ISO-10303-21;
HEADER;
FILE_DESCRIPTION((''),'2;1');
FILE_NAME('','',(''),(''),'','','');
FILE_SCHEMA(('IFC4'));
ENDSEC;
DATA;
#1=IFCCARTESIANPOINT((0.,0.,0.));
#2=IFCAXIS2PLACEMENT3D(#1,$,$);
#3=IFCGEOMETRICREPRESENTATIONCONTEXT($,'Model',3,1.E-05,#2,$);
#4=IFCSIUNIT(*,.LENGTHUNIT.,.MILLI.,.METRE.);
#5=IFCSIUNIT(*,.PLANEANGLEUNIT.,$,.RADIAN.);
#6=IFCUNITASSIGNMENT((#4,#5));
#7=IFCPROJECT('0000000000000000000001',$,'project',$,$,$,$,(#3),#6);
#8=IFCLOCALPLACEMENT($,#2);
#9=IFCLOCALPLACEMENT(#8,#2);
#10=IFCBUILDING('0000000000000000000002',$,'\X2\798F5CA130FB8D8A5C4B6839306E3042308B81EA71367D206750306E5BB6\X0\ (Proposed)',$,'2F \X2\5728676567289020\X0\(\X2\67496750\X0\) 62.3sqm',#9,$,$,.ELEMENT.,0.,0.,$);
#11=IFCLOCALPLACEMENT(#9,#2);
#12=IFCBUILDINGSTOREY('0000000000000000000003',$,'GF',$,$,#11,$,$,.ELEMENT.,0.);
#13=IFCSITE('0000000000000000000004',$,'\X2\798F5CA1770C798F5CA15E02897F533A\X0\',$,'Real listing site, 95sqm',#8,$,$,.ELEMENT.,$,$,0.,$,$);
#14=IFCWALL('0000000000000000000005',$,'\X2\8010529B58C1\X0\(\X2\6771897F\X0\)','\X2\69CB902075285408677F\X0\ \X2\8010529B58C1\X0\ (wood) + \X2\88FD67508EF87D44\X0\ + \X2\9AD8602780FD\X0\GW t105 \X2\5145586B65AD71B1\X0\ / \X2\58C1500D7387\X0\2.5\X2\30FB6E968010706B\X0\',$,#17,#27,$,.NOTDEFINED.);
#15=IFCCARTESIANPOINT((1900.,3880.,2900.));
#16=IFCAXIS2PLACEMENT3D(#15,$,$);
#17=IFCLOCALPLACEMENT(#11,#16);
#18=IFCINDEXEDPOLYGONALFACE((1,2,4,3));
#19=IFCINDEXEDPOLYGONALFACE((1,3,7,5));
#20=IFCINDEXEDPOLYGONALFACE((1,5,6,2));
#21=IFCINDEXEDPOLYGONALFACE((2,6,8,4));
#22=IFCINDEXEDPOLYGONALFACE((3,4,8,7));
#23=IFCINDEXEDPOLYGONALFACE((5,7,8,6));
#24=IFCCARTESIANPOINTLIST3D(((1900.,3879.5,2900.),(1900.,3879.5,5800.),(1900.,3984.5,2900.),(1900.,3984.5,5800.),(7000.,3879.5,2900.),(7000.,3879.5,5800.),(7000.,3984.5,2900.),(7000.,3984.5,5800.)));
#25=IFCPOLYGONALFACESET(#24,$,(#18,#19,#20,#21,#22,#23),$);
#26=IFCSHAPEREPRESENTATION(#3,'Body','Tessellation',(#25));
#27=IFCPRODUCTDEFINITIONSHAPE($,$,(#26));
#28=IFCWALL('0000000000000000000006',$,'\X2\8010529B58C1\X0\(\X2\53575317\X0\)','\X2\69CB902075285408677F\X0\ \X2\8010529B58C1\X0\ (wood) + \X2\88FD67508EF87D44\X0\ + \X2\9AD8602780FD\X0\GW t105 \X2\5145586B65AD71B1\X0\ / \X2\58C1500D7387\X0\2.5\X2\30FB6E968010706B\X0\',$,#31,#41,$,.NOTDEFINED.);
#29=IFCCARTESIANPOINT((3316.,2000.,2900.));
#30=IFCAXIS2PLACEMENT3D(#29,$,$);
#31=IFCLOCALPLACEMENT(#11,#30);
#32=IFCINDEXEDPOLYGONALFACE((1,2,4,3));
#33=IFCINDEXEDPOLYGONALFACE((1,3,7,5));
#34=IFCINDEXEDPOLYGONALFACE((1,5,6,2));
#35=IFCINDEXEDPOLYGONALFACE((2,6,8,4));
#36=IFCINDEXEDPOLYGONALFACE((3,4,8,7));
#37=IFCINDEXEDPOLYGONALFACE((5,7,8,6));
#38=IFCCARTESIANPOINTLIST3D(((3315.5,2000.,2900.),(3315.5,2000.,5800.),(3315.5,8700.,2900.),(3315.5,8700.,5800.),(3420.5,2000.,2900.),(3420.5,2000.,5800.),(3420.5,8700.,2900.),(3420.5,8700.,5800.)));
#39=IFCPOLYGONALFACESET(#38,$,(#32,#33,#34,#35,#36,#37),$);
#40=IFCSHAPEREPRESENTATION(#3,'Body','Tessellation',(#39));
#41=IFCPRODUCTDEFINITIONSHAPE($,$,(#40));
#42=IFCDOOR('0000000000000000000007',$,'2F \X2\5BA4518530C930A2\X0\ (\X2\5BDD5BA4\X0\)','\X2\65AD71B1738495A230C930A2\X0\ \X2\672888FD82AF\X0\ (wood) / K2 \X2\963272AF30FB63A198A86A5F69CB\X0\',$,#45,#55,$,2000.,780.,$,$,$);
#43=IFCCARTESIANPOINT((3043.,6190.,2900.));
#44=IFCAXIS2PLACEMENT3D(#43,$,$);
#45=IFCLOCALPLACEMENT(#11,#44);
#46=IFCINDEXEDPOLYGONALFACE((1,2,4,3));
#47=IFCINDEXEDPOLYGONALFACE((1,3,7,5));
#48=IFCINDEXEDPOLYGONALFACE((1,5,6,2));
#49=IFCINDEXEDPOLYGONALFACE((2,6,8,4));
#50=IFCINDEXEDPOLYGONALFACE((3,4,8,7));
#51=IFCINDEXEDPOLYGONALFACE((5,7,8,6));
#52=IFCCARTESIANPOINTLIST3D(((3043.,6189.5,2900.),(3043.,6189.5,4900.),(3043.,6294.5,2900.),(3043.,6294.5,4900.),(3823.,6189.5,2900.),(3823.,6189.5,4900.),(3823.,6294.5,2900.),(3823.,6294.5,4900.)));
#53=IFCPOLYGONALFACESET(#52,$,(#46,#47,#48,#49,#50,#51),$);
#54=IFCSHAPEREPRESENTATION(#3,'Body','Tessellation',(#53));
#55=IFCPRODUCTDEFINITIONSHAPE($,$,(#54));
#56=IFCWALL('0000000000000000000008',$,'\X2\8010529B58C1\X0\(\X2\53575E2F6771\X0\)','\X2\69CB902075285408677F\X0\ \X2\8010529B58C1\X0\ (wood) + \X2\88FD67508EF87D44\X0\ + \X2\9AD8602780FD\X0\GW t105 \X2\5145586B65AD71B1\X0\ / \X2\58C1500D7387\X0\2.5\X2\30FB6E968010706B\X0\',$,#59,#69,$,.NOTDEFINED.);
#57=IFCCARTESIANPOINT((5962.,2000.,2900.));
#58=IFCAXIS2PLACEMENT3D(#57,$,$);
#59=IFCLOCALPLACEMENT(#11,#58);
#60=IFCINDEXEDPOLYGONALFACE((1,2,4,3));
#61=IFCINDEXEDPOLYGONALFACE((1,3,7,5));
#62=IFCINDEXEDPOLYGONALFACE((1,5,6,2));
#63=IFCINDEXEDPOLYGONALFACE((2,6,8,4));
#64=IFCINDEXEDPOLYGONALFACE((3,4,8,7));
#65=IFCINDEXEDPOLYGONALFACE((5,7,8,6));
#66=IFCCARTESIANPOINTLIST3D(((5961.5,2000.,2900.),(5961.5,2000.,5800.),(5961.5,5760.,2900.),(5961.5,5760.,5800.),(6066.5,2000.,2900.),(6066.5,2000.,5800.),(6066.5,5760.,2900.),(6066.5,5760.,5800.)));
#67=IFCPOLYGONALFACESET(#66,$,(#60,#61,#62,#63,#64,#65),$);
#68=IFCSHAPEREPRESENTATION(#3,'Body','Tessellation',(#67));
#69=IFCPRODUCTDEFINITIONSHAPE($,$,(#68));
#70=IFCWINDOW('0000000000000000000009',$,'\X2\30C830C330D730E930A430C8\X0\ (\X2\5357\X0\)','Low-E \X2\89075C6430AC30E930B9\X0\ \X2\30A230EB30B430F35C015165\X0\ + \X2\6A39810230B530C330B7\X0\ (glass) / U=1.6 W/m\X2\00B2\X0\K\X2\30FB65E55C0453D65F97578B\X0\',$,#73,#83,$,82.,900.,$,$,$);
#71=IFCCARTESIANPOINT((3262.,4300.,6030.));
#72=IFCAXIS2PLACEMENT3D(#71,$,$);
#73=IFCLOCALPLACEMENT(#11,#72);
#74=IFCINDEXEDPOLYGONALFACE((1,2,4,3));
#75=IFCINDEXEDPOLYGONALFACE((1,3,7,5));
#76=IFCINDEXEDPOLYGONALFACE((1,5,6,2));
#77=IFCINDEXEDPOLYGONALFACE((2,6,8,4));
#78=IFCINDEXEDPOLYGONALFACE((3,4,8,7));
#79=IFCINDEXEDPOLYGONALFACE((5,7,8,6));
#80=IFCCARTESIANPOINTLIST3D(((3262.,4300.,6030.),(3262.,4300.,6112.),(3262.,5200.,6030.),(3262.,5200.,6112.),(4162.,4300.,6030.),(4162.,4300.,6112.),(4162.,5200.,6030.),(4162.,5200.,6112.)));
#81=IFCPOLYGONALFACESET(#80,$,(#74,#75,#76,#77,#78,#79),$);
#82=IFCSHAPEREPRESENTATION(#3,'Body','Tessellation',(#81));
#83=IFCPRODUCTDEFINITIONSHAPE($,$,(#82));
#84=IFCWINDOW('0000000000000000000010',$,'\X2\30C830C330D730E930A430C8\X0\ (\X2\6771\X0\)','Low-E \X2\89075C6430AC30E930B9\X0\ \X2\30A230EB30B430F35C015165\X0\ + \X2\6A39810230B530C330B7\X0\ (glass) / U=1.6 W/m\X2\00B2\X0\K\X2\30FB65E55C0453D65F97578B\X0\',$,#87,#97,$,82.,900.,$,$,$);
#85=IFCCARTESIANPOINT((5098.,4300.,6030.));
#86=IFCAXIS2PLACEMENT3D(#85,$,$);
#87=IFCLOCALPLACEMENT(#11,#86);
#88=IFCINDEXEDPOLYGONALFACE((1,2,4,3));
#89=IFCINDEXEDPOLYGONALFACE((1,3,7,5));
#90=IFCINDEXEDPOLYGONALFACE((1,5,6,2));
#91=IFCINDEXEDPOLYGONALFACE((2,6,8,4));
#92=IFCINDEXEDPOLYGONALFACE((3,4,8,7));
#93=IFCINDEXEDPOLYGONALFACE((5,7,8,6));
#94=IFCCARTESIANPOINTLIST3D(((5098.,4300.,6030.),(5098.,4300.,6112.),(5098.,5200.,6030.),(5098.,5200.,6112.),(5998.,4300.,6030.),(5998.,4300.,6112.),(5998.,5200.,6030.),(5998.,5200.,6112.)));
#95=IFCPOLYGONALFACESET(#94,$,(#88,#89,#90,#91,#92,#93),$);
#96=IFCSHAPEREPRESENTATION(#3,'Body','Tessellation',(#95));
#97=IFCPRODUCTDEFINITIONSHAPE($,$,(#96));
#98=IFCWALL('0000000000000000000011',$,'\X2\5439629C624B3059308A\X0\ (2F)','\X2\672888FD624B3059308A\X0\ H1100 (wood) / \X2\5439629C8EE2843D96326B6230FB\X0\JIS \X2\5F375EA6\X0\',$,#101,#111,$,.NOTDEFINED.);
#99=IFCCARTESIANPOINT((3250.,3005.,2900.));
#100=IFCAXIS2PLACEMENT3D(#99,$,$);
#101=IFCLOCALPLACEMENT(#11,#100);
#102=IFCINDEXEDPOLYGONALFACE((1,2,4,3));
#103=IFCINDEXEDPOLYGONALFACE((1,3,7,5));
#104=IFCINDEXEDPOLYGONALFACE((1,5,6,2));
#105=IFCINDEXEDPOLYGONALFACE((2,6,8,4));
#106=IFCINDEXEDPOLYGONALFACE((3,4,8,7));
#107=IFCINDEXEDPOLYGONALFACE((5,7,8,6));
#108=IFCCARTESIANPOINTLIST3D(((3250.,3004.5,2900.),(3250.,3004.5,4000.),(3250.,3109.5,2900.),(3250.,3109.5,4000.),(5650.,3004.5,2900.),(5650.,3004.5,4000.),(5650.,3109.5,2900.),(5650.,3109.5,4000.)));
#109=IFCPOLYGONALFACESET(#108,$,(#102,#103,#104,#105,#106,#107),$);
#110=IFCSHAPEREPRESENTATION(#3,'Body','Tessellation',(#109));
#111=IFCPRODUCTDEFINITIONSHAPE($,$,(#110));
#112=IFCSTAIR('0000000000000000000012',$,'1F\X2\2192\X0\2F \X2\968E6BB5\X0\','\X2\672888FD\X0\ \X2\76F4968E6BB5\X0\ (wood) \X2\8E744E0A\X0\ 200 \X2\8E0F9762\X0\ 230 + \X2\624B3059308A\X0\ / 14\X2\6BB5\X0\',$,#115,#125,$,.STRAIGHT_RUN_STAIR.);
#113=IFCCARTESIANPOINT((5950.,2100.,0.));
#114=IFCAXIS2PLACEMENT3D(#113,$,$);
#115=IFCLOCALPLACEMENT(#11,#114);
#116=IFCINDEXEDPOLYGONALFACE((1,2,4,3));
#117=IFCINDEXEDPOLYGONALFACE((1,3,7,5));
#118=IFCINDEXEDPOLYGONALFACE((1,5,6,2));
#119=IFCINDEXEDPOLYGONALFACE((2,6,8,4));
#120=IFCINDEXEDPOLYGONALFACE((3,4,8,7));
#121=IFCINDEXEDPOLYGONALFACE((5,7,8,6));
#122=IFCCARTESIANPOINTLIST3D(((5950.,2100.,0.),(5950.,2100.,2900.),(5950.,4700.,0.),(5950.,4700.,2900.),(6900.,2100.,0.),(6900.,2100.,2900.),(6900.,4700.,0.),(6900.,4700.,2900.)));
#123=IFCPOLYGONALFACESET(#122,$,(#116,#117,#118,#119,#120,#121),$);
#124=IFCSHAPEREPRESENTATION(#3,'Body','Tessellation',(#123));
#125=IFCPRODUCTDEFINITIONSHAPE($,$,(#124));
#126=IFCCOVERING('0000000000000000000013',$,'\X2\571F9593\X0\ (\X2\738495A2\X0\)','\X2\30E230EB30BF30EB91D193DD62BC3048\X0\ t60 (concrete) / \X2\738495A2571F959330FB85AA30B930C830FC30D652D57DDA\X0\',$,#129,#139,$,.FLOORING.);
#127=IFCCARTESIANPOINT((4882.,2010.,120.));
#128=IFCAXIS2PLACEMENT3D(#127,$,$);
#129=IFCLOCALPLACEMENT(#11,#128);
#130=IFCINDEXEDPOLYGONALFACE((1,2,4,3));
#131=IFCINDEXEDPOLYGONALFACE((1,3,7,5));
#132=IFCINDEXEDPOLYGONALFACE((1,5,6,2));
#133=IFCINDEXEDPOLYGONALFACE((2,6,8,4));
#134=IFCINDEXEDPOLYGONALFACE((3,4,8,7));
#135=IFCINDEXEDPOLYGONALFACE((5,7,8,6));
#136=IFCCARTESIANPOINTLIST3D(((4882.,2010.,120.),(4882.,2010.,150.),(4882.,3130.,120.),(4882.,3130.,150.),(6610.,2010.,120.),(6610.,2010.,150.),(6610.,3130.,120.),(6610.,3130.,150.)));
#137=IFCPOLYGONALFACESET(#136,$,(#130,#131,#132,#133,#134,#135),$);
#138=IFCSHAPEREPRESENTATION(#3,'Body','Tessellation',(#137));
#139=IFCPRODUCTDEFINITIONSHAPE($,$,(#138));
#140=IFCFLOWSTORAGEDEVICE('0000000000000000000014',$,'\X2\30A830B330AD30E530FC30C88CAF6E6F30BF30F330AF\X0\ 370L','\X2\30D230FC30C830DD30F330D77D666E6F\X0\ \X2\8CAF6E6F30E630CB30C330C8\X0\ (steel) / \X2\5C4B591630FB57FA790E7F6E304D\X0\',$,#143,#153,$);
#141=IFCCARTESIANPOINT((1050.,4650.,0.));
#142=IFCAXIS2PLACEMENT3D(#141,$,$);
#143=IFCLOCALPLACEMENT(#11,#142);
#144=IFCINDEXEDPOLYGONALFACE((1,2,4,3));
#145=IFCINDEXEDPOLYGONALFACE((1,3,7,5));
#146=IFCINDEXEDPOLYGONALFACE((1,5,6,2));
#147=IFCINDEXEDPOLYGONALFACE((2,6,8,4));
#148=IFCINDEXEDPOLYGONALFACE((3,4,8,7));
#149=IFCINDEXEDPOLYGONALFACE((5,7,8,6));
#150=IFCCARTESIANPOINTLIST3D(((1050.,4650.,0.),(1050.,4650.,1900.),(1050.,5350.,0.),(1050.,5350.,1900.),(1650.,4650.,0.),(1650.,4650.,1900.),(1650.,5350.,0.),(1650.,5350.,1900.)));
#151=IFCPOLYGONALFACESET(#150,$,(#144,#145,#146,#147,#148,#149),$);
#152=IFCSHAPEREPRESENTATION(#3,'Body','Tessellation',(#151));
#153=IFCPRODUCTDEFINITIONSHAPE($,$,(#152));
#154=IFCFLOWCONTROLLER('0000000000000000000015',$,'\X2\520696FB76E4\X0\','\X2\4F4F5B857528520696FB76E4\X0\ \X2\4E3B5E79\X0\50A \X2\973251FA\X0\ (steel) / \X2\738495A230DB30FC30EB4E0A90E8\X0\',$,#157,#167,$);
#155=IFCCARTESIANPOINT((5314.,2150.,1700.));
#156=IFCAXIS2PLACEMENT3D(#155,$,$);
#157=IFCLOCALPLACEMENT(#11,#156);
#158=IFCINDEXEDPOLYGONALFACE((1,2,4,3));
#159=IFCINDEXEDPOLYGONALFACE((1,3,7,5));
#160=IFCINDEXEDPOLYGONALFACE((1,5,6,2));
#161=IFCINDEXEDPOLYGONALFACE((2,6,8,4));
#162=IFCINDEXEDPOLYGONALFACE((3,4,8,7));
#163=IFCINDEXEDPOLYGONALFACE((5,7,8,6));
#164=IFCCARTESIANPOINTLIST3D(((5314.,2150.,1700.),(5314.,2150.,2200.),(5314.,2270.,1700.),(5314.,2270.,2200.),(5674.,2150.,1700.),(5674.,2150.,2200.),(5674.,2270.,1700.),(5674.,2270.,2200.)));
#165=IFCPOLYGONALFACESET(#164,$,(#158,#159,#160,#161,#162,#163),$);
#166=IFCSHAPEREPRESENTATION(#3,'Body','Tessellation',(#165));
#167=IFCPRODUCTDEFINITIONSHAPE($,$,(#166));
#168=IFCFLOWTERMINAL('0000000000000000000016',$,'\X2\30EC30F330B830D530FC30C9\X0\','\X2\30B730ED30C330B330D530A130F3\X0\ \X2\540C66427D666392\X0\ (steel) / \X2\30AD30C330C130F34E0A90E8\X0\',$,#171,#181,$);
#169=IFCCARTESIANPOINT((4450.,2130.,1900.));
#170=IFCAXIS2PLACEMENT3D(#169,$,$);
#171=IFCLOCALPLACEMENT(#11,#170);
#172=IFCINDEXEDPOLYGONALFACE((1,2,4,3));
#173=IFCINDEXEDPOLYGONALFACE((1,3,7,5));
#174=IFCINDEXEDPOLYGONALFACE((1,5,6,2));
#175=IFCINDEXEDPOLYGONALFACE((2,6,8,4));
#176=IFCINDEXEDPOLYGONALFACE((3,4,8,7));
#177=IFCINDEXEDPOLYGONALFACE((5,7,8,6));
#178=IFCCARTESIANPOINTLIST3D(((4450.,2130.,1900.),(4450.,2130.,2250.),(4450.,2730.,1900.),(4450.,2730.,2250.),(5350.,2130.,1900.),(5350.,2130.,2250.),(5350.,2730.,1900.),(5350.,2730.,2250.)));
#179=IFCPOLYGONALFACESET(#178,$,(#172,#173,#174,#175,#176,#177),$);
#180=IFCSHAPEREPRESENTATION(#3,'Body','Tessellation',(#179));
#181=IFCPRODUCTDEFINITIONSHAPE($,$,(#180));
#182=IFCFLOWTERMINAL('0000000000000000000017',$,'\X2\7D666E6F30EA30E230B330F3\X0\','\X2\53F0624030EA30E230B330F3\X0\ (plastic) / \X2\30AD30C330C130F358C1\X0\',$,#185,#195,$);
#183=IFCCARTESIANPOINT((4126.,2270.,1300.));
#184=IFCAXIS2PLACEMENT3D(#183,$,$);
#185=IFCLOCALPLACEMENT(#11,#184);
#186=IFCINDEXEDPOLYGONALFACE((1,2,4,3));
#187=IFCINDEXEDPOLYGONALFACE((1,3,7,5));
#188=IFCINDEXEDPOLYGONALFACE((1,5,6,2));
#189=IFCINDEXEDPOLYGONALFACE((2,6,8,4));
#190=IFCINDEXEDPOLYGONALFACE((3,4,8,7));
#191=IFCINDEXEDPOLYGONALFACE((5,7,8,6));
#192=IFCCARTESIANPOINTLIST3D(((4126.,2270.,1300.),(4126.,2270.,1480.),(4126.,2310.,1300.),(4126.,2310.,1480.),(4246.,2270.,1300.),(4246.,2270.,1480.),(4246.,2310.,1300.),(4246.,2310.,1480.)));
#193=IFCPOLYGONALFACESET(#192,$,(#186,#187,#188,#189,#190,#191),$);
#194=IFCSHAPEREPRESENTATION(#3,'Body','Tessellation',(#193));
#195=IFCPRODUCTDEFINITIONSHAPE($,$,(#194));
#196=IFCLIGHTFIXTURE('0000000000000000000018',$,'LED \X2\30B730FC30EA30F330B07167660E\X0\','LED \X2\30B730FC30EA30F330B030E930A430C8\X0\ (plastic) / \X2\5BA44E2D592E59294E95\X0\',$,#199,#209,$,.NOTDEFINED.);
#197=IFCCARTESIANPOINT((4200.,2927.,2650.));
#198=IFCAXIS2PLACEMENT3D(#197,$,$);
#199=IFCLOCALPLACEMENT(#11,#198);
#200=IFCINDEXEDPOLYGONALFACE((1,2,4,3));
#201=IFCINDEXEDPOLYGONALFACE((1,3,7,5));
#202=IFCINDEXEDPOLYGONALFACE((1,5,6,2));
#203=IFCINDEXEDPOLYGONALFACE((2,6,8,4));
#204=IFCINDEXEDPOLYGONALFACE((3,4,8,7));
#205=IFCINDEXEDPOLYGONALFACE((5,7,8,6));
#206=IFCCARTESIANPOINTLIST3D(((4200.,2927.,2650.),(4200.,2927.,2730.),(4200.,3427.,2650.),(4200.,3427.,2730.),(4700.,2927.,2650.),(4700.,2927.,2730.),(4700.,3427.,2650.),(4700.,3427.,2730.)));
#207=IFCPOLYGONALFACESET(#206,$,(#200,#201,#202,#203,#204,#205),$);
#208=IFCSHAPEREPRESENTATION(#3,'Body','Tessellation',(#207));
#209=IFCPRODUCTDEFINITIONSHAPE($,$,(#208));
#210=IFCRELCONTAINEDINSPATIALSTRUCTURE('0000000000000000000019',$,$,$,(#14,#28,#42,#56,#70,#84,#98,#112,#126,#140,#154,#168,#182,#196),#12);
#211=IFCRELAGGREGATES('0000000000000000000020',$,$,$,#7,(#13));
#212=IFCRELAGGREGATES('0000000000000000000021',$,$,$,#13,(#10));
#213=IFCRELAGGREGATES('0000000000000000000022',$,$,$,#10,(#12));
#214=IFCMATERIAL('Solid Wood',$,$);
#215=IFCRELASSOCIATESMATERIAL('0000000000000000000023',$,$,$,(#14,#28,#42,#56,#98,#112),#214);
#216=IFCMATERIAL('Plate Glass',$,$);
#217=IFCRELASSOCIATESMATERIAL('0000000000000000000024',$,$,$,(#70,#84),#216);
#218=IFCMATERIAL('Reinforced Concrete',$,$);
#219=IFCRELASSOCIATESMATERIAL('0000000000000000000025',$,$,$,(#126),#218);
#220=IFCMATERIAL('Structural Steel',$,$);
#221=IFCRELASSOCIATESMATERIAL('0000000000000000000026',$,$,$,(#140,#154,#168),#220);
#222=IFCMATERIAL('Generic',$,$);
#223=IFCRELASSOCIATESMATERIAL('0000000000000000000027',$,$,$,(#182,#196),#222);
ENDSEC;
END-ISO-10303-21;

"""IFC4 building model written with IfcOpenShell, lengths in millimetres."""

from ifc_helpers import new_model, si_unit, frame, frame_2d, origin, place, context, project, spatial, rectangle, extrude, material, element, fill, save


model = new_model("IFC4")

# Units and contexts
model_context = context("Model", 3, precision=1e-05, world=origin())
ifc_project = project(units=[si_unit("LENGTHUNIT", "METRE", prefix="MILLI"), si_unit("PLANEANGLEUNIT", "RADIAN")], contexts=[model_context])

# Site, building, storey
site_placement = place(None, origin())
site = spatial("IfcSite", under=ifc_project, at=site_placement, Name="福岡県福岡市西区", ObjectType="Real listing site, 95sqm", CompositionType="ELEMENT", RefElevation=0.0)
building_placement = place(site_placement, origin())
building = spatial("IfcBuilding", under=site, at=building_placement, Name="福岡・越屋根のある自然素材の家 (Proposed)", ObjectType="2F 在来木造(杉材) 62.3sqm", CompositionType="ELEMENT", ElevationOfRefHeight=0.0, ElevationOfTerrain=0.0)
storey_placement = place(building_placement, origin())
storey = spatial("IfcBuildingStorey", under=building, at=storey_placement, Name="GF", CompositionType="ELEMENT", Elevation=0.0)

# Shared definitions
ifc_material_1 = material(Name="Solid Wood")

# Wall
wall_1_placement = place(storey_placement, frame((1900.0, 3880.0, 2900.0)))
element("IfcWall", 1, at=wall_1_placement, inside=storey, material=ifc_material_1, Name="耐力壁(東西)", Description="構造用合板 耐力壁 (wood) + 製材軸組 + 高性能GW t105 充填断熱 / 壁倍率2.5・準耐火", PredefinedType="NOTDEFINED", context=model_context, shape_type="SweptSolid", body=[
    extrude(rectangle(XDim=5100.0, YDim=105.0, at=frame_2d((2550.0, 52.0))), frame((1900.0, 3880.0, 2900.0)), (0.0, 0.0, 1.0), 2900.0),
])

# Wall, opening, door
wall_2_placement = place(storey_placement, frame((3316.0, 2000.0, 2900.0)))
wall_2 = element("IfcWall", 2, at=wall_2_placement, inside=storey, material=ifc_material_1, Name="耐力壁(南北)", Description="構造用合板 耐力壁 (wood) + 製材軸組 + 高性能GW t105 充填断熱 / 壁倍率2.5・準耐火", PredefinedType="NOTDEFINED", context=model_context, shape_type="SweptSolid", body=[
    extrude(rectangle(XDim=105.0, YDim=6700.0, at=frame_2d((52.0, 3350.0))), frame((3316.0, 2000.0, 2900.0)), (0.0, 0.0, 1.0), 2900.0),
])
opening_placement = place(storey_placement, frame((3043.0, 6190.0, 2900.0)))
opening = element("IfcOpeningElement", 3, at=opening_placement, cuts=wall_2, PredefinedType="NOTDEFINED", context=model_context, shape_type="SweptSolid", body=[
    extrude(rectangle(XDim=780.0, YDim=105.0, at=frame_2d((390.0, 52.0))), frame((3043.0, 6190.0, 2900.0)), (0.0, 0.0, 1.0), 2000.0),
])
door_placement = place(storey_placement, frame((3043.0, 6190.0, 2900.0)))
door = element("IfcDoor", 4, at=door_placement, inside=storey, material=ifc_material_1, Name="2F 室内ドア (寝室)", Description="断熱玄関ドア 木製芯 (wood) / K2 防犯・採風機構", OverallHeight=2000.0, OverallWidth=780.0, context=model_context, shape_type="SweptSolid", body=[
    extrude(rectangle(XDim=780.0, YDim=105.0, at=frame_2d((390.0, 52.0))), frame((3043.0, 6190.0, 2900.0)), (0.0, 0.0, 1.0), 2000.0),
])
fill(opening, door)

# Wall
wall_3_placement = place(storey_placement, frame((5962.0, 2000.0, 2900.0)))
element("IfcWall", 5, at=wall_3_placement, inside=storey, material=ifc_material_1, Name="耐力壁(南帯東)", Description="構造用合板 耐力壁 (wood) + 製材軸組 + 高性能GW t105 充填断熱 / 壁倍率2.5・準耐火", PredefinedType="NOTDEFINED", context=model_context, shape_type="SweptSolid", body=[
    extrude(rectangle(XDim=105.0, YDim=3760.0, at=frame_2d((52.0, 1880.0))), frame((5962.0, 2000.0, 2900.0)), (0.0, 0.0, 1.0), 2900.0),
])

# Windows
ifc_material_2 = material(Name="Plate Glass")
window_1_placement = place(storey_placement, frame((3262.0, 4300.0, 6030.0)))
element("IfcWindow", 6, at=window_1_placement, inside=storey, material=ifc_material_2, Name="トップライト (南)", Description="Low-E 複層ガラス アルゴン封入 + 樹脂サッシ (glass) / U=1.6 W/m²K・日射取得型", OverallHeight=82.0, OverallWidth=900.0, context=model_context, shape_type="SweptSolid", body=[
    extrude(rectangle(XDim=900.0, YDim=900.0, at=frame_2d((450.0, 450.0))), frame((3262.0, 4300.0, 6030.0)), (0.0, 0.0, 1.0), 82.0),
])
window_2_placement = place(storey_placement, frame((5098.0, 4300.0, 6030.0)))
element("IfcWindow", 7, at=window_2_placement, inside=storey, material=ifc_material_2, Name="トップライト (東)", Description="Low-E 複層ガラス アルゴン封入 + 樹脂サッシ (glass) / U=1.6 W/m²K・日射取得型", OverallHeight=82.0, OverallWidth=900.0, context=model_context, shape_type="SweptSolid", body=[
    extrude(rectangle(XDim=900.0, YDim=900.0, at=frame_2d((450.0, 450.0))), frame((5098.0, 4300.0, 6030.0)), (0.0, 0.0, 1.0), 82.0),
])

# Wall
wall_4_placement = place(storey_placement, frame((3250.0, 3005.0, 2900.0)))
element("IfcWall", 8, at=wall_4_placement, inside=storey, material=ifc_material_1, Name="吹抜手すり (2F)", Description="木製手すり H1100 (wood) / 吹抜転落防止・JIS 強度", PredefinedType="NOTDEFINED", context=model_context, shape_type="SweptSolid", body=[
    extrude(rectangle(XDim=2400.0, YDim=105.0, at=frame_2d((1200.0, 52.0))), frame((3250.0, 3005.0, 2900.0)), (0.0, 0.0, 1.0), 1100.0),
])

# Stair
stair_placement = place(storey_placement, frame((5950.0, 2100.0, 0.0)))
element("IfcStair", 9, at=stair_placement, inside=storey, material=ifc_material_1, Name="1F→2F 階段", Description="木製 直階段 (wood) 蹴上 200 踏面 230 + 手すり / 14段", PredefinedType="STRAIGHT_RUN_STAIR", context=model_context, shape_type="SweptSolid", body=[
    extrude(rectangle(XDim=950.0, YDim=2600.0, at=frame_2d((475.0, 1300.0))), frame((5950.0, 2100.0, 0.0)), (0.0, 0.0, 1.0), 2900.0),
])

# Covering
ifc_material_3 = material(Name="Reinforced Concrete")
covering_placement = place(storey_placement, frame((4882.0, 2010.0, 120.0)))
element("IfcCovering", 10, at=covering_placement, inside=storey, material=ifc_material_3, Name="土間 (玄関)", Description="モルタル金鏝押え t60 (concrete) / 玄関土間・薪ストーブ動線", PredefinedType="FLOORING", context=model_context, shape_type="SweptSolid", body=[
    extrude(rectangle(XDim=1728.0, YDim=1120.0, at=frame_2d((864.0, 560.0))), frame((4882.0, 2010.0, 120.0)), (0.0, 0.0, 1.0), 30.0),
])

# Flow storage device
ifc_material_4 = material(Name="Structural Steel")
flow_storage_device_placement = place(storey_placement, frame((1050.0, 4650.0, 0.0)))
element("IfcFlowStorageDevice", 11, at=flow_storage_device_placement, inside=storey, material=ifc_material_4, Name="エコキュート貯湯タンク 370L", Description="ヒートポンプ給湯 貯湯ユニット (steel) / 屋外・基礎置き", context=model_context, shape_type="SweptSolid", body=[
    extrude(rectangle(XDim=600.0, YDim=700.0, at=frame_2d((300.0, 350.0))), frame((1050.0, 4650.0, 0.0)), (0.0, 0.0, 1.0), 1900.0),
])

# Flow controller
flow_controller_placement = place(storey_placement, frame((5314.0, 2150.0, 1700.0)))
element("IfcFlowController", 12, at=flow_controller_placement, inside=storey, material=ifc_material_4, Name="分電盤", Description="住宅用分電盤 主幹50A 露出 (steel) / 玄関ホール上部", context=model_context, shape_type="SweptSolid", body=[
    extrude(rectangle(XDim=360.0, YDim=120.0, at=frame_2d((180.0, 60.0))), frame((5314.0, 2150.0, 1700.0)), (0.0, 0.0, 1.0), 500.0),
])

# Flow terminals
flow_terminal_1_placement = place(storey_placement, frame((4450.0, 2130.0, 1900.0)))
element("IfcFlowTerminal", 13, at=flow_terminal_1_placement, inside=storey, material=ifc_material_4, Name="レンジフード", Description="シロッコファン 同時給排 (steel) / キッチン上部", context=model_context, shape_type="SweptSolid", body=[
    extrude(rectangle(XDim=900.0, YDim=600.0, at=frame_2d((450.0, 300.0))), frame((4450.0, 2130.0, 1900.0)), (0.0, 0.0, 1.0), 350.0),
])
ifc_material_5 = material(Name="Generic")
flow_terminal_2_placement = place(storey_placement, frame((4126.0, 2270.0, 1300.0)))
element("IfcFlowTerminal", 14, at=flow_terminal_2_placement, inside=storey, material=ifc_material_5, Name="給湯リモコン", Description="台所リモコン (plastic) / キッチン壁", context=model_context, shape_type="SweptSolid", body=[
    extrude(rectangle(XDim=120.0, YDim=40.0, at=frame_2d((60.0, 20.0))), frame((4126.0, 2270.0, 1300.0)), (0.0, 0.0, 1.0), 180.0),
])

# Light fixture
light_fixture_1_placement = place(storey_placement, frame((4200.0, 2927.0, 2650.0)))
element("IfcLightFixture", 15, at=light_fixture_1_placement, inside=storey, material=ifc_material_5, Name="LED シーリング照明", Description="LED シーリングライト (plastic) / 室中央天井", PredefinedType="NOTDEFINED", context=model_context, shape_type="SweptSolid", body=[
    extrude(rectangle(XDim=500.0, YDim=500.0, at=frame_2d((250.0, 250.0))), frame((4200.0, 2927.0, 2650.0)), (0.0, 0.0, 1.0), 80.0),
])

save(model, "model.ifc")
